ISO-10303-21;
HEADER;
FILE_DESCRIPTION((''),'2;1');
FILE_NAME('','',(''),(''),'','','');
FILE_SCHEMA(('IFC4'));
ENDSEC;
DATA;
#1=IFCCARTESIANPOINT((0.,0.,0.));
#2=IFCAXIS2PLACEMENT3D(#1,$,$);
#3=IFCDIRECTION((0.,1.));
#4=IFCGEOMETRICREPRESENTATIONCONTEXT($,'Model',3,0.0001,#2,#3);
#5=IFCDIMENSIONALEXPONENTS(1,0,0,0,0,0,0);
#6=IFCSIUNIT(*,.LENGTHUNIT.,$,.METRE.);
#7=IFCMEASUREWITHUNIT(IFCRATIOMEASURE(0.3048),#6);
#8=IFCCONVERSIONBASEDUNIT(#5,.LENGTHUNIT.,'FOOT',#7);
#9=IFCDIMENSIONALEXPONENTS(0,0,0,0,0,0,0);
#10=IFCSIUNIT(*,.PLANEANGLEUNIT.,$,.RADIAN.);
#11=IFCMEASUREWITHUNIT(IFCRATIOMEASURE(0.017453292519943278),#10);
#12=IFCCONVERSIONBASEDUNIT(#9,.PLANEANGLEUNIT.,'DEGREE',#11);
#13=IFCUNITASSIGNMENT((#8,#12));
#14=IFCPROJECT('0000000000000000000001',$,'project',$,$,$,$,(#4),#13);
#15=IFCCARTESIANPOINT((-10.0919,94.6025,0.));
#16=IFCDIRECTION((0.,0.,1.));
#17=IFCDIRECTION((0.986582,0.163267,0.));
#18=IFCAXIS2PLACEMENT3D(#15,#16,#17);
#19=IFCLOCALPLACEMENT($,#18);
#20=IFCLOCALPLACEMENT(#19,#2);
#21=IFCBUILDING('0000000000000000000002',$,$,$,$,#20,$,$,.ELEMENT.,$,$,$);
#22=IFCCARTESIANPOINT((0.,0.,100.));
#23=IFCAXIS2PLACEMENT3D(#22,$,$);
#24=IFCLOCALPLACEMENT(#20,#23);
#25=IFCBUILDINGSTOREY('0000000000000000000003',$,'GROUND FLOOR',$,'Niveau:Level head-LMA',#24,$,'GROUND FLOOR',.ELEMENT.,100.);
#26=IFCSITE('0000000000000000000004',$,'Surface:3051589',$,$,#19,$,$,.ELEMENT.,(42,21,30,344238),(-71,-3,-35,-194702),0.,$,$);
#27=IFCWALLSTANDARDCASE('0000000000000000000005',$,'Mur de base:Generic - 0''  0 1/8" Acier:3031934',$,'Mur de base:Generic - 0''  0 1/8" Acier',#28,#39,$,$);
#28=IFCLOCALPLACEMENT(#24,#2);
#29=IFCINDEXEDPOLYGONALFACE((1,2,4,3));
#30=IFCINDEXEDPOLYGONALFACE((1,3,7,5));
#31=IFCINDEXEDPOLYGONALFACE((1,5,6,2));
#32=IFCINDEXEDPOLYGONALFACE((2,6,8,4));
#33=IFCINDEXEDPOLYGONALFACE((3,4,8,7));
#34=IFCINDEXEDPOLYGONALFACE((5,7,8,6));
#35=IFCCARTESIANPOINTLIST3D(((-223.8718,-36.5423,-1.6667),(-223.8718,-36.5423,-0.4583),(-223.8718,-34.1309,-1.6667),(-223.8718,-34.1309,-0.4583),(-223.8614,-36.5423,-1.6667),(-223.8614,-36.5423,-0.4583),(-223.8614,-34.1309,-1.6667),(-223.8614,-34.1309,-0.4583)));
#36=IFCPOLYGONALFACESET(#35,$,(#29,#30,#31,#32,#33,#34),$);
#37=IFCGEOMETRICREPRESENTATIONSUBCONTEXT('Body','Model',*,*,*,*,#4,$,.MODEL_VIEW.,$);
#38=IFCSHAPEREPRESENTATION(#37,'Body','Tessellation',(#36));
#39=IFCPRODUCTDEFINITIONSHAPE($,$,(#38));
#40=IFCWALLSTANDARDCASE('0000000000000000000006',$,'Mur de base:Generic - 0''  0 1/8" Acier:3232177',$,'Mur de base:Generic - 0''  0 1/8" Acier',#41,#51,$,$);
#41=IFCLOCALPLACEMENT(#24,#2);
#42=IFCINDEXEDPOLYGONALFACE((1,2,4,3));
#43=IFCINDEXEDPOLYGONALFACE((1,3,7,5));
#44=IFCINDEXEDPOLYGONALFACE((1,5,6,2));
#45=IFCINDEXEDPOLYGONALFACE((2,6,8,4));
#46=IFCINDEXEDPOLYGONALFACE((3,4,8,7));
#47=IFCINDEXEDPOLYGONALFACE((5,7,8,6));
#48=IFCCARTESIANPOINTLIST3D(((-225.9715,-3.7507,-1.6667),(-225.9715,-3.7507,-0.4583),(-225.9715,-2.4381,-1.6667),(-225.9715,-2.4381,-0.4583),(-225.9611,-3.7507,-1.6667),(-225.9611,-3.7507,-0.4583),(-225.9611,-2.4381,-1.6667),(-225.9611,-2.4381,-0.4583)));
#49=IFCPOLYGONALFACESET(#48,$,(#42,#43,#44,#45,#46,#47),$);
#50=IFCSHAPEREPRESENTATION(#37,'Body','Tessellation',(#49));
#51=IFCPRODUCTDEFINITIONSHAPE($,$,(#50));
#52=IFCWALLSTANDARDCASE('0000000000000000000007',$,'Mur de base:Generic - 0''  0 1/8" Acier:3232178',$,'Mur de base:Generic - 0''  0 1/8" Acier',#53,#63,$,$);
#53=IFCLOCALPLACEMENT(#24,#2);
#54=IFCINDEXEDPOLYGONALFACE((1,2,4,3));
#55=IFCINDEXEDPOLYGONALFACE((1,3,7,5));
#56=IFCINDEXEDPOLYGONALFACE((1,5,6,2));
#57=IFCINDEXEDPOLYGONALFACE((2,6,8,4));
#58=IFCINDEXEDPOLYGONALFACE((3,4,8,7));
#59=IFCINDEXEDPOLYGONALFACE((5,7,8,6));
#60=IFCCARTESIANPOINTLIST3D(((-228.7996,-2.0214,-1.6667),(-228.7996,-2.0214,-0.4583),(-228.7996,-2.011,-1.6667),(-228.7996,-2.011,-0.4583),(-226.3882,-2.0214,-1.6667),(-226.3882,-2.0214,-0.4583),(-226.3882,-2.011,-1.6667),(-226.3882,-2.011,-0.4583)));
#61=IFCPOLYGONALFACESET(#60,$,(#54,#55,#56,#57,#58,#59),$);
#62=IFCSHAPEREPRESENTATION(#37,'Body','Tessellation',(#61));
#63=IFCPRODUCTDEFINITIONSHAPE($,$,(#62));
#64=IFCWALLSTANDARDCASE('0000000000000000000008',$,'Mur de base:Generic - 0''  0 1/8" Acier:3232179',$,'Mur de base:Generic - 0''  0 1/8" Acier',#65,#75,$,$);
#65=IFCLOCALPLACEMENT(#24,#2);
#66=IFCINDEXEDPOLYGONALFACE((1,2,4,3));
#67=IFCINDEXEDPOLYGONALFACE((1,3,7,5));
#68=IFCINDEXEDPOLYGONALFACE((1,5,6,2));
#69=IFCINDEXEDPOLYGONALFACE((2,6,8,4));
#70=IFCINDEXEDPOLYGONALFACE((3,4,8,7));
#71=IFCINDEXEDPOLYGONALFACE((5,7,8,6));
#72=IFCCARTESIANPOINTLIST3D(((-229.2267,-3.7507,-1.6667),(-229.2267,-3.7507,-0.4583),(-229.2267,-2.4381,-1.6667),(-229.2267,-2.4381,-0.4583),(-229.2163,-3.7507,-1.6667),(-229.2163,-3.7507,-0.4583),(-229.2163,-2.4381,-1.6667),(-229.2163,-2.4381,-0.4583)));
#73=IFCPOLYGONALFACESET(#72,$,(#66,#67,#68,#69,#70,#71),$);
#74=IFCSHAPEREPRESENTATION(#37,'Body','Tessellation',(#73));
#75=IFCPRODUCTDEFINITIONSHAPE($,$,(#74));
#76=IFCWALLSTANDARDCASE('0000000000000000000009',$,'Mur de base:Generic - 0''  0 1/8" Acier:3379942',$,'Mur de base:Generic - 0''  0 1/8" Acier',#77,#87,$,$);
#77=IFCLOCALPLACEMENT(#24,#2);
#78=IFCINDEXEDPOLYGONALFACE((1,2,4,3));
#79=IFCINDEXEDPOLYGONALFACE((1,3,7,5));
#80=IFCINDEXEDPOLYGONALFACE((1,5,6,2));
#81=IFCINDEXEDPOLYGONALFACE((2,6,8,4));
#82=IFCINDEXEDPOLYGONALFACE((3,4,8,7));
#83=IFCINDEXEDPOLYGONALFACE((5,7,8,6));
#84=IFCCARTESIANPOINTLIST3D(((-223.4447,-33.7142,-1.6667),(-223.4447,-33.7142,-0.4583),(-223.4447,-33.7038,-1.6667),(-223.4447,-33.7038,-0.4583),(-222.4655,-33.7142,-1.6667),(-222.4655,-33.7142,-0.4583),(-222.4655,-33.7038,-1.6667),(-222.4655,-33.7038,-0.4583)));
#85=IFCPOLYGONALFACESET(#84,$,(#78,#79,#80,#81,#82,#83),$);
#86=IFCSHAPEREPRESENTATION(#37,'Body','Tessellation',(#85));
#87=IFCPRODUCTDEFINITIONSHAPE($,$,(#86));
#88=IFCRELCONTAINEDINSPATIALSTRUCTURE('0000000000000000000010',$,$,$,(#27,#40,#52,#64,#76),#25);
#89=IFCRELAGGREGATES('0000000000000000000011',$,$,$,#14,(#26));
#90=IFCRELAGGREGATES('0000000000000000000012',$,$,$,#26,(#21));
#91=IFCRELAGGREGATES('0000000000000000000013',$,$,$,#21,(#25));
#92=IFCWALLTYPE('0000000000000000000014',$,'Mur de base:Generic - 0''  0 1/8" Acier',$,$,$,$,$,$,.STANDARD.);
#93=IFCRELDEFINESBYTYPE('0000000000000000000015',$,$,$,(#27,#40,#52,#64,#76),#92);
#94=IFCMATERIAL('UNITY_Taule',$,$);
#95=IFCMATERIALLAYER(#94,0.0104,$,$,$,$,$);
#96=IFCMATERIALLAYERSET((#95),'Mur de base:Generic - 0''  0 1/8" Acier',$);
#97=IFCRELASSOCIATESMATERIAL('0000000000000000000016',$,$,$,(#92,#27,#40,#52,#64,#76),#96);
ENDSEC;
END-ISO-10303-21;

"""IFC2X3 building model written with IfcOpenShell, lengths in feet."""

from ifc_helpers import new_model, entity, si_unit, converted_unit, direction, frame, frame_2d, origin, place, context, subcontext, project, spatial, rectangle, extrude, material, layer, layer_set, layer_usage, type_object, element, save


model = new_model("IFC2X3")

# Units and contexts
model_context = context("Model", 3, precision=0.0001, world=origin(), true_north=direction((0.0, 1.0)))
body_context = subcontext(model_context, "Body", "Model", "MODEL_VIEW")
ifc_project = project(units=[converted_unit("LENGTHUNIT", "FOOT", entity("IfcRatioMeasure", 0.3048), si_unit("LENGTHUNIT", "METRE"), dimensions=[1, 0, 0, 0, 0, 0, 0]), converted_unit("PLANEANGLEUNIT", "DEGREE", entity("IfcRatioMeasure", 0.017453292519943278), si_unit("PLANEANGLEUNIT", "RADIAN"), dimensions=[0, 0, 0, 0, 0, 0, 0])], contexts=[model_context])

# Site, building, storey
site_placement = place(None, frame((-10.0919, 94.6025, 0.0), z_axis=(0.0, 0.0, 1.0), x_axis=(0.986582, 0.163267, 0.0)))
site = spatial("IfcSite", under=ifc_project, at=site_placement, Name="Surface:3051589", CompositionType="ELEMENT", RefLatitude=(42, 21, 30, 344238), RefLongitude=(-71, -3, -35, -194702), RefElevation=0.0)
building_placement = place(site_placement, origin())
building = spatial("IfcBuilding", under=site, at=building_placement, CompositionType="ELEMENT")
storey_placement = place(building_placement, frame((0.0, 0.0, 100.0)))
storey = spatial("IfcBuildingStorey", under=building, at=storey_placement, Name="GROUND FLOOR", ObjectType="Niveau:Level head-LMA", LongName="GROUND FLOOR", CompositionType="ELEMENT", Elevation=100.0)

# Walls
ifc_material_1 = material(Name="UNITY_Taule")
ifc_layer = layer(ifc_material_1, 0.0104)
ifc_layer_set = layer_set([ifc_layer], Name="Mur de base:Generic - 0'  0 1/8\" Acier")
wall_type = type_object("IfcWallType", Name="Mur de base:Generic - 0'  0 1/8\" Acier", PredefinedType="STANDARD", material=ifc_layer_set)
ifc_layer_usage_1 = layer_usage(ifc_layer_set, "AXIS2", "NEGATIVE", 0.0052)
wall_1_placement = place(storey_placement, frame((-223.8666, -34.1309, -1.6667), z_axis=(0.0, 0.0, 1.0), x_axis=(0.0, -1.0, 0.0)))
element("IfcWallStandardCase", 1, at=wall_1_placement, inside=storey, type_object=wall_type, material=ifc_layer_usage_1, Name="Mur de base:Generic - 0'  0 1/8\" Acier:3031934", ObjectType="Mur de base:Generic - 0'  0 1/8\" Acier", context=body_context, shape_type="SweptSolid", body=[
    extrude(rectangle(XDim=2.4115, YDim=0.0104, at=frame_2d((1.2057, 0.0), x_axis=(-1.0, 0.0))), origin(), (0.0, 0.0, 1.0), 1.2083),
])
ifc_layer_usage_2 = layer_usage(ifc_layer_set, "AXIS2", "NEGATIVE", 0.0052)
wall_2_placement = place(storey_placement, frame((-225.9663, -3.7507, -1.6667), z_axis=(0.0, 0.0, 1.0), x_axis=(0.0, 1.0, 0.0)))
element("IfcWallStandardCase", 2, at=wall_2_placement, inside=storey, type_object=wall_type, material=ifc_layer_usage_2, Name="Mur de base:Generic - 0'  0 1/8\" Acier:3232177", ObjectType="Mur de base:Generic - 0'  0 1/8\" Acier", context=body_context, shape_type="SweptSolid", body=[
    extrude(rectangle(XDim=1.3126, YDim=0.0104, at=frame_2d((0.6563, 0.0), x_axis=(-1.0, 0.0))), origin(), (0.0, 0.0, 1.0), 1.2083),
])
ifc_layer_usage_3 = layer_usage(ifc_layer_set, "AXIS2", "NEGATIVE", 0.0052)
wall_3_placement = place(storey_placement, frame((-226.3882, -2.0162, -1.6667), z_axis=(0.0, 0.0, 1.0), x_axis=(-1.0, 0.0, 0.0)))
element("IfcWallStandardCase", 3, at=wall_3_placement, inside=storey, type_object=wall_type, material=ifc_layer_usage_3, Name="Mur de base:Generic - 0'  0 1/8\" Acier:3232178", ObjectType="Mur de base:Generic - 0'  0 1/8\" Acier", context=body_context, shape_type="SweptSolid", body=[
    extrude(rectangle(XDim=2.4115, YDim=0.0104, at=frame_2d((1.2057, 0.0), x_axis=(-1.0, 0.0))), origin(), (0.0, 0.0, 1.0), 1.2083),
])
ifc_layer_usage_4 = layer_usage(ifc_layer_set, "AXIS2", "POSITIVE", -0.0052)
wall_4_placement = place(storey_placement, frame((-229.2215, -3.7507, -1.6667), z_axis=(0.0, 0.0, 1.0), x_axis=(0.0, 1.0, 0.0)))
element("IfcWallStandardCase", 4, at=wall_4_placement, inside=storey, type_object=wall_type, material=ifc_layer_usage_4, Name="Mur de base:Generic - 0'  0 1/8\" Acier:3232179", ObjectType="Mur de base:Generic - 0'  0 1/8\" Acier", context=body_context, shape_type="SweptSolid", body=[
    extrude(rectangle(XDim=1.3126, YDim=0.0104, at=frame_2d((0.6563, 0.0), x_axis=(-1.0, 0.0))), origin(), (0.0, 0.0, 1.0), 1.2083),
])
ifc_layer_usage_5 = layer_usage(ifc_layer_set, "AXIS2", "NEGATIVE", 0.0052)
wall_5_placement = place(storey_placement, frame((-222.4655, -33.709, -1.6667), z_axis=(0.0, 0.0, 1.0), x_axis=(-1.0, 0.0, 0.0)))
element("IfcWallStandardCase", 5, at=wall_5_placement, inside=storey, type_object=wall_type, material=ifc_layer_usage_5, Name="Mur de base:Generic - 0'  0 1/8\" Acier:3379942", ObjectType="Mur de base:Generic - 0'  0 1/8\" Acier", context=body_context, shape_type="SweptSolid", body=[
    extrude(rectangle(XDim=0.9792, YDim=0.0104, at=frame_2d((0.4896, 0.0), x_axis=(-1.0, 0.0))), origin(), (0.0, 0.0, 1.0), 1.2083),
])

save(model, "model.ifc")
